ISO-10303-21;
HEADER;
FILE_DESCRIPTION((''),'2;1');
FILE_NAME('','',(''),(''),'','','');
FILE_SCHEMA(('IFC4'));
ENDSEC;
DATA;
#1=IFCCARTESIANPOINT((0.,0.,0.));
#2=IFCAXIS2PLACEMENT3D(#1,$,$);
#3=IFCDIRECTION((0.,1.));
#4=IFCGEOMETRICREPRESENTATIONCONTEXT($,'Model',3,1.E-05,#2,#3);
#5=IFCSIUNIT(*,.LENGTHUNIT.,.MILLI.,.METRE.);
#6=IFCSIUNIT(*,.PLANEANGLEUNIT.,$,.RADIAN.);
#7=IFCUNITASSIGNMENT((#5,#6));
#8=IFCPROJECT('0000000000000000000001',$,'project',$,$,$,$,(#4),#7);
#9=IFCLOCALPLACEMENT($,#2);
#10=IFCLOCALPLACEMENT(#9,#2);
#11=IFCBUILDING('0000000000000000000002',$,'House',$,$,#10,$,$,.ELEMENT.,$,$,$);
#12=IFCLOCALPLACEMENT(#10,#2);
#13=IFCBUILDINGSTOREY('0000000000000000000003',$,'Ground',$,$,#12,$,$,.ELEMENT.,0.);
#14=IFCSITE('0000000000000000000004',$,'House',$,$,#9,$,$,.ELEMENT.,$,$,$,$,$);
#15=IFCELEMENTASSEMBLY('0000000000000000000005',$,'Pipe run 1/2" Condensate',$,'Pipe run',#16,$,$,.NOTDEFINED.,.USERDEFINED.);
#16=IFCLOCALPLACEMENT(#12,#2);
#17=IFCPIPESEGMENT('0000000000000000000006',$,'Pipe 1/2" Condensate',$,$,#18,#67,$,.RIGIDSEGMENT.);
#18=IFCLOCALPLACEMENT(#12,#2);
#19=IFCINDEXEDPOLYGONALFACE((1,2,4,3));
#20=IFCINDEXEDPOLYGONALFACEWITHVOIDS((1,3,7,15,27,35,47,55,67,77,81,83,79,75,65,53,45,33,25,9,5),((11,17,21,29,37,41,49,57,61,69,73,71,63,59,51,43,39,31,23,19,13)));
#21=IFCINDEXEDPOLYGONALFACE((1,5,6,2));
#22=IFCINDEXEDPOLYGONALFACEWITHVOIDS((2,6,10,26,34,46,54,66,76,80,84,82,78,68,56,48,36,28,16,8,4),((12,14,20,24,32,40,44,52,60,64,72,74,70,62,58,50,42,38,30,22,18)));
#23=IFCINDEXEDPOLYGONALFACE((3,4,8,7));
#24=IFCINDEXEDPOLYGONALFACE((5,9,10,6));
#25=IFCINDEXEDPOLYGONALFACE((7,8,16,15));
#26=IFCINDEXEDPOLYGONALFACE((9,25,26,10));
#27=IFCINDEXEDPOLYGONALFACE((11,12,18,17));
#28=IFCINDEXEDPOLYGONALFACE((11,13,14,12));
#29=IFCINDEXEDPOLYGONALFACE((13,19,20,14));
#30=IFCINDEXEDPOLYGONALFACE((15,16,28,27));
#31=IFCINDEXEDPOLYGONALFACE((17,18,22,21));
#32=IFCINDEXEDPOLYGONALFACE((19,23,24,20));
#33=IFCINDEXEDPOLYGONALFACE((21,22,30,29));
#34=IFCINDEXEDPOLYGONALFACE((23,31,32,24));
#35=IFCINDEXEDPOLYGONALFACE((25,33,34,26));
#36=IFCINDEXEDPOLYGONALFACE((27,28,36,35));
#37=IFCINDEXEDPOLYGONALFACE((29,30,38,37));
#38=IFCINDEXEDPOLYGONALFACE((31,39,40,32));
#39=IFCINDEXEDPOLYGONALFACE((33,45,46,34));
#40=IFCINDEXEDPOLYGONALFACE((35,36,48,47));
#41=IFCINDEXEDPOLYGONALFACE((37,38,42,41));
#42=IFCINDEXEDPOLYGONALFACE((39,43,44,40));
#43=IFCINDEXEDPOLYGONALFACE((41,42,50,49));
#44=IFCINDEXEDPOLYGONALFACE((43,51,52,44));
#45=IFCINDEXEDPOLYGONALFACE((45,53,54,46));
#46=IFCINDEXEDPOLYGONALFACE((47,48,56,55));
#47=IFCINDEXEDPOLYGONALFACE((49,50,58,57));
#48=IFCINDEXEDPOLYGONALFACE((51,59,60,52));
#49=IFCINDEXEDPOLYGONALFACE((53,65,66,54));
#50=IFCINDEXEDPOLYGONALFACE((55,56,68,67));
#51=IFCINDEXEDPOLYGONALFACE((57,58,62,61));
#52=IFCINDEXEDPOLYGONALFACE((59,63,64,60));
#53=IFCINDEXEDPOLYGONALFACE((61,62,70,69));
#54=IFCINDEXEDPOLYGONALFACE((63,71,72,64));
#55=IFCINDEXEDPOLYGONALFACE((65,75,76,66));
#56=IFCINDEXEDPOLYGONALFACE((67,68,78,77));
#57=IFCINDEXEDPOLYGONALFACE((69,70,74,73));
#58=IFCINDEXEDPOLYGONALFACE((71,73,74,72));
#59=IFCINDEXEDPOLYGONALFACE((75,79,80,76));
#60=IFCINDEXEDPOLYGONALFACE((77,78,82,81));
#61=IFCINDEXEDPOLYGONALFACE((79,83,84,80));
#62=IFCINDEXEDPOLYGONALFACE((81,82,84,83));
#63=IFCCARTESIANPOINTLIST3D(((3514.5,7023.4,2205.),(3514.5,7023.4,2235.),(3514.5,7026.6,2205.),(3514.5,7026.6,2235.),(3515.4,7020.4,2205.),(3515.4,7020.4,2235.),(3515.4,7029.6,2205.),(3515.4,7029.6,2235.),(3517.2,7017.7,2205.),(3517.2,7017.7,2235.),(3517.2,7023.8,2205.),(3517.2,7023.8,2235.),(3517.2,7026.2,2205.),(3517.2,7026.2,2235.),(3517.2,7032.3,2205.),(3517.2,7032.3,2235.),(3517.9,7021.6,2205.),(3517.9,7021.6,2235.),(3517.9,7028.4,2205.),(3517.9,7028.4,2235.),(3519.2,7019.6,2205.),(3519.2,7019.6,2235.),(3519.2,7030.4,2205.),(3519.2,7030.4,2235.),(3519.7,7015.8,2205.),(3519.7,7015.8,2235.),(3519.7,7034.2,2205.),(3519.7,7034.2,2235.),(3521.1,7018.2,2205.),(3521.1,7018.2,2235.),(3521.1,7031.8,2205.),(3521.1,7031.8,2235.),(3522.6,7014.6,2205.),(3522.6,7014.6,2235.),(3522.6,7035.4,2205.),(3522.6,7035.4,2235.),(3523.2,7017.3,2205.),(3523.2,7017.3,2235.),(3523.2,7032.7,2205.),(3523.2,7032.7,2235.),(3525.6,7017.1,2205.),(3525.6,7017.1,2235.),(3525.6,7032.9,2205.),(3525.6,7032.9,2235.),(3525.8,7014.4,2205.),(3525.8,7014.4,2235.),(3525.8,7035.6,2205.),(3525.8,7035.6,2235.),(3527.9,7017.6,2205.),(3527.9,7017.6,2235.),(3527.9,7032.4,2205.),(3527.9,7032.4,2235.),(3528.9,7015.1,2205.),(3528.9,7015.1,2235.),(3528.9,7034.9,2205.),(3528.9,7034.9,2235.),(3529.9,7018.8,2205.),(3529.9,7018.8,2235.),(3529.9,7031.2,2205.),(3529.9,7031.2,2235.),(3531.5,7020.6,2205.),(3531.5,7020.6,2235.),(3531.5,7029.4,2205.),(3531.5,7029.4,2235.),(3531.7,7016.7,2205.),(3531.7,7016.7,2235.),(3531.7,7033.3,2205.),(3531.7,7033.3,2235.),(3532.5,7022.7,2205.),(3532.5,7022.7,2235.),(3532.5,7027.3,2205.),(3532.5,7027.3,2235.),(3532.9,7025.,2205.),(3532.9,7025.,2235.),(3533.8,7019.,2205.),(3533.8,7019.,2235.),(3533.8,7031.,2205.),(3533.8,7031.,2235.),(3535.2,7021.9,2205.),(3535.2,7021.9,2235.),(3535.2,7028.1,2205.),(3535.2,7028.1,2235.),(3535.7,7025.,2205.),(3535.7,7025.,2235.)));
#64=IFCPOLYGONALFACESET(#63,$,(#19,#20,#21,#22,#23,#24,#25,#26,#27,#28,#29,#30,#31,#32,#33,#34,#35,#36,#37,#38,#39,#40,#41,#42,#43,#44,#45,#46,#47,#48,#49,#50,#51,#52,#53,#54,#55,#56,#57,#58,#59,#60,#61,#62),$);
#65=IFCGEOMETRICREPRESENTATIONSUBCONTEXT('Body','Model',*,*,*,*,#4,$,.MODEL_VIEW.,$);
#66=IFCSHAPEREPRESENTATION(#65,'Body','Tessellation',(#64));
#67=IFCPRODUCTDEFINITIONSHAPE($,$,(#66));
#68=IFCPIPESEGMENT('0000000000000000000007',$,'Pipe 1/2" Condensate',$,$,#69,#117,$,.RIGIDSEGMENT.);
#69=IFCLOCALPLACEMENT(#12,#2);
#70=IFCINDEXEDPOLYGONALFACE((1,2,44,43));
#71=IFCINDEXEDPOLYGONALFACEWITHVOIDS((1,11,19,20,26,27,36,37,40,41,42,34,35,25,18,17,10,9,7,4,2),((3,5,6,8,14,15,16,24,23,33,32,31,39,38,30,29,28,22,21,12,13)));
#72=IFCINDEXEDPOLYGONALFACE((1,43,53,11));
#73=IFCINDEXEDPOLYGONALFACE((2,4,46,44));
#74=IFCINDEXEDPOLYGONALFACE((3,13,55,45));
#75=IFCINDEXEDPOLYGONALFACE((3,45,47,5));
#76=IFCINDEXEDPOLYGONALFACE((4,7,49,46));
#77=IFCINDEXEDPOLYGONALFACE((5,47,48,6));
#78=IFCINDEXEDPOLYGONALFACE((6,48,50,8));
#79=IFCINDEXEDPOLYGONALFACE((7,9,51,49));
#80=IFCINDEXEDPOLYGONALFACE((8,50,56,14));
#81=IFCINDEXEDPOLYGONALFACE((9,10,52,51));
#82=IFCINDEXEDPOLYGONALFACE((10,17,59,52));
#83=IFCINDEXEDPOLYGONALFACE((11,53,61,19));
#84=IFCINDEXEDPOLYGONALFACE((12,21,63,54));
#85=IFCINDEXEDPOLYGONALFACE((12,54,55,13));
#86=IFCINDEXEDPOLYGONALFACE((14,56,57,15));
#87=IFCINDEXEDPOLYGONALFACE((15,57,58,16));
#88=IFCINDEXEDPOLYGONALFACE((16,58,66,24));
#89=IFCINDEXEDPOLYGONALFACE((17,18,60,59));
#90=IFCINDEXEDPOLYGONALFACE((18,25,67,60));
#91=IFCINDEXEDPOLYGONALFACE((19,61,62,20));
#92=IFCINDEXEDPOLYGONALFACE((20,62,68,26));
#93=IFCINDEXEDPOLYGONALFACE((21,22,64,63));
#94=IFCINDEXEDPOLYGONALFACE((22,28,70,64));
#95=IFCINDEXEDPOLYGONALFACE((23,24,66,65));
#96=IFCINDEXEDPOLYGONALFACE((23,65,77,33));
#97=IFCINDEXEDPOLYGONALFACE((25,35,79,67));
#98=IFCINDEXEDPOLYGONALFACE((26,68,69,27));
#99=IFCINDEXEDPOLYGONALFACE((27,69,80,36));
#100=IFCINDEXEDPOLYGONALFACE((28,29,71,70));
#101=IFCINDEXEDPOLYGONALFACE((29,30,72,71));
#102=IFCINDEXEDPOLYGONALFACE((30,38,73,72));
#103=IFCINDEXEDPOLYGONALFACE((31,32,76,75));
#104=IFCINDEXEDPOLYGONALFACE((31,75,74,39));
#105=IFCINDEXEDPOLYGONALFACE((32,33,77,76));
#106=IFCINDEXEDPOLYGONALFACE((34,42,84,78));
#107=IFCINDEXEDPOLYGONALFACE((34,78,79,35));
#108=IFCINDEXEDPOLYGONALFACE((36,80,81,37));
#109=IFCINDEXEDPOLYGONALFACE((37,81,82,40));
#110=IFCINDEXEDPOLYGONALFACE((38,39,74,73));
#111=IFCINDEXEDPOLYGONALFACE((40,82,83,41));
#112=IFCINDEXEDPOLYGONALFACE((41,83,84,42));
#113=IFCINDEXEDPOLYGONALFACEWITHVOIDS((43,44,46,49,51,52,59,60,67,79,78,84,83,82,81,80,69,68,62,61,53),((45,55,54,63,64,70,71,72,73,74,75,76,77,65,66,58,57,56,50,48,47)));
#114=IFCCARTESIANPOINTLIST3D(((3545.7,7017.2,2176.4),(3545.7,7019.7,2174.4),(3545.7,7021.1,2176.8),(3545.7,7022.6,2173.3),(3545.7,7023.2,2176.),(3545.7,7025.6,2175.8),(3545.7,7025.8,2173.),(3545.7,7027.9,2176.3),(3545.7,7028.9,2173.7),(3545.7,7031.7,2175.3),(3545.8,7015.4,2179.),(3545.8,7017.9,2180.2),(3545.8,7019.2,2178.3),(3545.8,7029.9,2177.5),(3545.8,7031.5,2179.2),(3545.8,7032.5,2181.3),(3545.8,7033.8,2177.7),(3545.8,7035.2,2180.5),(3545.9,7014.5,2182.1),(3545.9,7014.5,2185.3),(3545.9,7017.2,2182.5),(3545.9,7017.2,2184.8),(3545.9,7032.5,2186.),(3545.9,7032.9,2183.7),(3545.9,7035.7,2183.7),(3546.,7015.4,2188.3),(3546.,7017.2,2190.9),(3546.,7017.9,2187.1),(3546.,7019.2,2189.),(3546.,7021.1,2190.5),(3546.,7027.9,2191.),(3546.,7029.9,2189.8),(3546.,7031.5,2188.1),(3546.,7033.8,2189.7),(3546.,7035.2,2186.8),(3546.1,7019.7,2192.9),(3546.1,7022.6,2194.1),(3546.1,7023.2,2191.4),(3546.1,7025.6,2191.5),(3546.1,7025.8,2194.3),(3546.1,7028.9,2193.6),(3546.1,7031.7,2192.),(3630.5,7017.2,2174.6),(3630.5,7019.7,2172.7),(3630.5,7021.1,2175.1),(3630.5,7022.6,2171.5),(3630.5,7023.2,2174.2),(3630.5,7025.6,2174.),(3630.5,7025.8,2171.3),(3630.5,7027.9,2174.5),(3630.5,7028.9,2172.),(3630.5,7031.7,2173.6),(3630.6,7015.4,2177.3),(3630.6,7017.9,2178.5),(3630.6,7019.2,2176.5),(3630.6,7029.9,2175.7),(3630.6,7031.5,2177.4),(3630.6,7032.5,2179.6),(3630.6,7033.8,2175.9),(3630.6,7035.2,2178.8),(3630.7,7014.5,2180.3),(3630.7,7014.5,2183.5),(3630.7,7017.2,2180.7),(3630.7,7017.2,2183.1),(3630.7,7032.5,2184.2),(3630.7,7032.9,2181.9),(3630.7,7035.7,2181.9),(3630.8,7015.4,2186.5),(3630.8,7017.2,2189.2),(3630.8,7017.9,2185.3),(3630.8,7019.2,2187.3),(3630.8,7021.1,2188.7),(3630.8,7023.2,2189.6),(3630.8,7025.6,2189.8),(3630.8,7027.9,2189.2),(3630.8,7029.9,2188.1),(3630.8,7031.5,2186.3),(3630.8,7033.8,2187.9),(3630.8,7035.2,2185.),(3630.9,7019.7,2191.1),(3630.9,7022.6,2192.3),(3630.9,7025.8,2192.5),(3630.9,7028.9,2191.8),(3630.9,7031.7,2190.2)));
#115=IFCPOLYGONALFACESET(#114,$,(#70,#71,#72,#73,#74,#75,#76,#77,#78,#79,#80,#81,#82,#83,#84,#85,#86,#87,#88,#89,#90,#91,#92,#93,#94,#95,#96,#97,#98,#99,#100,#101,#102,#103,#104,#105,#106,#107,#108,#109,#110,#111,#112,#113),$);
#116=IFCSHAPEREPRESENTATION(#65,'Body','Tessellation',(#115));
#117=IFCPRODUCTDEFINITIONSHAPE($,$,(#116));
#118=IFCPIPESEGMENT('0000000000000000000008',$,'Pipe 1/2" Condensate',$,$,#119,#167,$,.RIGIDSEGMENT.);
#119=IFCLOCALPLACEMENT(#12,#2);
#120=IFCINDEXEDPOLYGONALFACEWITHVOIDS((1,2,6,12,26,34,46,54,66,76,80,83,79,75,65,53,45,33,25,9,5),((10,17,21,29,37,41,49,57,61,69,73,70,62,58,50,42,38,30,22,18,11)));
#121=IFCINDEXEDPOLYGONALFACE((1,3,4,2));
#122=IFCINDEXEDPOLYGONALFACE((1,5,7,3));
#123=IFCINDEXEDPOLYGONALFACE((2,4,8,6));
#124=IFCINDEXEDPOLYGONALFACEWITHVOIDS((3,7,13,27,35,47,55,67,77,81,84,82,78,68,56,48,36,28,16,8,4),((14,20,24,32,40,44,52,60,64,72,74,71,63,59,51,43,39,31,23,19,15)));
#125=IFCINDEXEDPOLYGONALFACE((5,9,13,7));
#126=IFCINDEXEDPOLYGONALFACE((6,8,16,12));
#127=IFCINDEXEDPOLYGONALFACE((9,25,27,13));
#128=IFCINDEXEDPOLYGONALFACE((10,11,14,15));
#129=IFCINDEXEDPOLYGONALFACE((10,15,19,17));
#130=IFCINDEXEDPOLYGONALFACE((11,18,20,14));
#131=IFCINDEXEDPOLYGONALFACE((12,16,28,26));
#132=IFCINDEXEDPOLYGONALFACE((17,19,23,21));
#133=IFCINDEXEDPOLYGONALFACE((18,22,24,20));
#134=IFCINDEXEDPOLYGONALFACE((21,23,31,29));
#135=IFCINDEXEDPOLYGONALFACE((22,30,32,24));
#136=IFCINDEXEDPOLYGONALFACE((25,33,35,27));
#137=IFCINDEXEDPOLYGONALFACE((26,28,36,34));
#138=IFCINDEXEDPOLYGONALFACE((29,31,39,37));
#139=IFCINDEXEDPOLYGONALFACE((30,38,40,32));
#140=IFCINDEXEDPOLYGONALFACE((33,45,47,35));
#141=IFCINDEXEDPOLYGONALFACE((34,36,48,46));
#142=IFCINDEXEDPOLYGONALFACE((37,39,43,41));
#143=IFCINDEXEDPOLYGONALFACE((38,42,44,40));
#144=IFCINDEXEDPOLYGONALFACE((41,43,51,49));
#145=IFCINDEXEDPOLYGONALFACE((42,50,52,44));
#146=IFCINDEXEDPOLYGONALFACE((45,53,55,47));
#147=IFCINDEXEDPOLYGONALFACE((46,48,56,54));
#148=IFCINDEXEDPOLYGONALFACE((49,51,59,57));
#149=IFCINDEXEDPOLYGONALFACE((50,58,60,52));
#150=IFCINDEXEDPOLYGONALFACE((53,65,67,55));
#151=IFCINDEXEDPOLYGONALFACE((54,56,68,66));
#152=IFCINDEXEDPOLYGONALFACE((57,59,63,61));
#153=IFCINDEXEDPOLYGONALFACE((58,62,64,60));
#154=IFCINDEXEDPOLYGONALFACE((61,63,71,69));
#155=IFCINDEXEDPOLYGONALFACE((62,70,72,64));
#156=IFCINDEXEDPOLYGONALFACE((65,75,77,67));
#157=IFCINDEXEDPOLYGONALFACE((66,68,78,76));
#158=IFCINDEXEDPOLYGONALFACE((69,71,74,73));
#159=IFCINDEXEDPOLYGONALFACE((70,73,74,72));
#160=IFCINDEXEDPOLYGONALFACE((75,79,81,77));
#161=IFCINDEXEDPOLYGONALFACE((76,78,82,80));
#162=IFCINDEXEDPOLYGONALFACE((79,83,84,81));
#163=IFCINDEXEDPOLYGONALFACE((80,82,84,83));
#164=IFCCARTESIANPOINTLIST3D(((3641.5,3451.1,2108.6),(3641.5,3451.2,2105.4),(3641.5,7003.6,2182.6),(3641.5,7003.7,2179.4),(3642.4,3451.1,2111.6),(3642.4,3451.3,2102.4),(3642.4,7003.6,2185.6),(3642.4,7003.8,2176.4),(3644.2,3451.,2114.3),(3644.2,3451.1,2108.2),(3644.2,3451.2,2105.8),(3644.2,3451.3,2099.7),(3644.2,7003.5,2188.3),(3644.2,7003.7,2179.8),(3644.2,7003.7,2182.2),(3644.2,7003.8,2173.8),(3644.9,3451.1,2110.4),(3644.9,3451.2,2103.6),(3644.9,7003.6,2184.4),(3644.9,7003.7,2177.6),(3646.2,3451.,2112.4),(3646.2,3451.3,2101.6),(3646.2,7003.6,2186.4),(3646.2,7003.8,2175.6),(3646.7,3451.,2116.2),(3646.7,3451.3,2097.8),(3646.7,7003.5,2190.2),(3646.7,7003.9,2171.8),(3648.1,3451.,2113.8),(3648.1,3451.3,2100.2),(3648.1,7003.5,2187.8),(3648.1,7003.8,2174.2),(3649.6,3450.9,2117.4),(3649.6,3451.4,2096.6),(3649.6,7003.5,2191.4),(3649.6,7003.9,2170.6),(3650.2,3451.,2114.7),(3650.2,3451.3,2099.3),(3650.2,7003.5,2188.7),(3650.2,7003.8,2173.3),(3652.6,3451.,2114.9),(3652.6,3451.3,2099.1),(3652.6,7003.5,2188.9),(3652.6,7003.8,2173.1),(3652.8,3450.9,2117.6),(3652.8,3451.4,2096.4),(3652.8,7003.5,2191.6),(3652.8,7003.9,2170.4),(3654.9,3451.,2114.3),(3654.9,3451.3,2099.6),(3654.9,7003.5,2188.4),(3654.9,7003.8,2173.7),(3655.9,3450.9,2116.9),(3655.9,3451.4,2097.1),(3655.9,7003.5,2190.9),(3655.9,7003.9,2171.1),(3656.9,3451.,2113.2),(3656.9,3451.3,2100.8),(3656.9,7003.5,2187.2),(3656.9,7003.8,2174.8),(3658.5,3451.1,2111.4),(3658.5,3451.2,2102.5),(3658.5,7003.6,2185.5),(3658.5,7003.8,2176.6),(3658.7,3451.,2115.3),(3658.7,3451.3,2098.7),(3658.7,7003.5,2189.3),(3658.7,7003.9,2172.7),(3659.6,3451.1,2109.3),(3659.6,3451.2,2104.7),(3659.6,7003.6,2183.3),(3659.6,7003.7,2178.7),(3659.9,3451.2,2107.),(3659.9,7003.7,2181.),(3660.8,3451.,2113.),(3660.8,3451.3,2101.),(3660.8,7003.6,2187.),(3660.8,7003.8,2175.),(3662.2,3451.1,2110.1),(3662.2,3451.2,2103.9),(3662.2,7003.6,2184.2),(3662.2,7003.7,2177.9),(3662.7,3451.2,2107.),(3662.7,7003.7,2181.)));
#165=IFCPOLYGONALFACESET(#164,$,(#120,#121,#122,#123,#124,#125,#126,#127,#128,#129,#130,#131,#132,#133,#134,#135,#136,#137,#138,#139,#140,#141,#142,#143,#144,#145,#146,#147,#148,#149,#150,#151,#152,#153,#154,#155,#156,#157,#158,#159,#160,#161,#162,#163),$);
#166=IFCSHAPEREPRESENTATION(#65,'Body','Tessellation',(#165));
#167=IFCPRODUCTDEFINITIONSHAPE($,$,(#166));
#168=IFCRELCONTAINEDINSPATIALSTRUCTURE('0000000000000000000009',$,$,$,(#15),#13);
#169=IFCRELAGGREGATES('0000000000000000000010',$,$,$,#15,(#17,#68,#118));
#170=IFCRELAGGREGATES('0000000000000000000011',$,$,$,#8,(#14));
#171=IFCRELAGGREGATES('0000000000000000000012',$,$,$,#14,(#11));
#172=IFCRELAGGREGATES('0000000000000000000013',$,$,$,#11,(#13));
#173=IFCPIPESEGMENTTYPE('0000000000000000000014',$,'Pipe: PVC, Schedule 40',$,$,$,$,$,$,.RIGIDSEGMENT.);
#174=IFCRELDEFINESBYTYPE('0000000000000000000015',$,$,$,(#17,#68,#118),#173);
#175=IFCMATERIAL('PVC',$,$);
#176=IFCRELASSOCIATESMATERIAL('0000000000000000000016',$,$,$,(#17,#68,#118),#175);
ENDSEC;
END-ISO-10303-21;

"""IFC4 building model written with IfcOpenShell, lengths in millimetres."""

from ifc_helpers import new_model, si_unit, direction, frame, origin, origin_with_axes, origin_2d, place, context, subcontext, project, spatial, hollow_circle, extrude, material, type_object, element, aggregate, save


model = new_model("IFC4")

# Units and contexts
model_context = context("Model", 3, precision=1e-05, world=origin(), true_north=direction((0.0, 1.0)))
body_context = subcontext(model_context, "Body", "Model", "MODEL_VIEW")
ifc_project = project(units=[si_unit("LENGTHUNIT", "METRE", prefix="MILLI"), si_unit("PLANEANGLEUNIT", "RADIAN")], contexts=[model_context])

# Site, building, storey
site_placement = place(None, origin())
site = spatial("IfcSite", under=ifc_project, at=site_placement, Name="House", CompositionType="ELEMENT")
building_placement = place(site_placement, origin())
building = spatial("IfcBuilding", under=site, at=building_placement, Name="House", CompositionType="ELEMENT")
storey_placement = place(building_placement, origin())
storey = spatial("IfcBuildingStorey", under=building, at=storey_placement, Name="Ground", CompositionType="ELEMENT", Elevation=0.0)

# Element assembly
ifc_material_1 = material(Name="PVC")
assembly_1_placement = place(storey_placement, origin_with_axes())
assembly_1 = element("IfcElementAssembly", 1, at=assembly_1_placement, inside=storey, Name="Pipe run 1/2\" Condensate", ObjectType="Pipe run", AssemblyPlace="NOTDEFINED", PredefinedType="USERDEFINED")

# Pipe segments
pipe_segment_type_1 = type_object("IfcPipeSegmentType", Name="Pipe: PVC, Schedule 40", PredefinedType="RIGIDSEGMENT")
pipe_segment_1_placement = place(storey_placement, origin_with_axes())
pipe_segment_1 = element("IfcPipeSegment", 2, at=pipe_segment_1_placement, type_object=pipe_segment_type_1, material=ifc_material_1, Name="Pipe 1/2\" Condensate", PredefinedType="RIGIDSEGMENT", context=body_context, shape_type="SweptSolid", body=[
    extrude(hollow_circle(Radius=10.7, WallThickness=2.8, at=origin_2d()), frame((3525.0, 7025.0, 2235.0), z_axis=(0.0, 0.0, -1.0), x_axis=(1.0, 0.0, 0.0)), (0.0, 0.0, 1.0), 30.0),
])
pipe_segment_2_placement = place(storey_placement, origin_with_axes())
pipe_segment_2 = element("IfcPipeSegment", 3, at=pipe_segment_2_placement, type_object=pipe_segment_type_1, material=ifc_material_1, Name="Pipe 1/2\" Condensate", PredefinedType="RIGIDSEGMENT", context=body_context, shape_type="SweptSolid", body=[
    extrude(hollow_circle(Radius=10.7, WallThickness=2.8, at=origin_2d()), frame((3545.9, 7025.0, 2183.7), z_axis=(0.999783, 0.0, -0.020829), x_axis=(0.0, 1.0, 0.0)), (0.0, 0.0, 1.0), 84.8),
])
pipe_segment_3_placement = place(storey_placement, origin_with_axes())
pipe_segment_3 = element("IfcPipeSegment", 4, at=pipe_segment_3_placement, type_object=pipe_segment_type_1, material=ifc_material_1, Name="Pipe 1/2\" Condensate", PredefinedType="RIGIDSEGMENT", context=body_context, shape_type="SweptSolid", body=[
    extrude(hollow_circle(Radius=10.7, WallThickness=2.8, at=origin_2d()), frame((3652.0, 7003.7, 2181.0), z_axis=(0.0, -0.999783, -0.020829), x_axis=(1.0, 0.0, 0.0)), (0.0, 0.0, 1.0), 3553.3),
])
aggregate(assembly_1, [pipe_segment_1, pipe_segment_2, pipe_segment_3])

save(model, "model.ifc")
